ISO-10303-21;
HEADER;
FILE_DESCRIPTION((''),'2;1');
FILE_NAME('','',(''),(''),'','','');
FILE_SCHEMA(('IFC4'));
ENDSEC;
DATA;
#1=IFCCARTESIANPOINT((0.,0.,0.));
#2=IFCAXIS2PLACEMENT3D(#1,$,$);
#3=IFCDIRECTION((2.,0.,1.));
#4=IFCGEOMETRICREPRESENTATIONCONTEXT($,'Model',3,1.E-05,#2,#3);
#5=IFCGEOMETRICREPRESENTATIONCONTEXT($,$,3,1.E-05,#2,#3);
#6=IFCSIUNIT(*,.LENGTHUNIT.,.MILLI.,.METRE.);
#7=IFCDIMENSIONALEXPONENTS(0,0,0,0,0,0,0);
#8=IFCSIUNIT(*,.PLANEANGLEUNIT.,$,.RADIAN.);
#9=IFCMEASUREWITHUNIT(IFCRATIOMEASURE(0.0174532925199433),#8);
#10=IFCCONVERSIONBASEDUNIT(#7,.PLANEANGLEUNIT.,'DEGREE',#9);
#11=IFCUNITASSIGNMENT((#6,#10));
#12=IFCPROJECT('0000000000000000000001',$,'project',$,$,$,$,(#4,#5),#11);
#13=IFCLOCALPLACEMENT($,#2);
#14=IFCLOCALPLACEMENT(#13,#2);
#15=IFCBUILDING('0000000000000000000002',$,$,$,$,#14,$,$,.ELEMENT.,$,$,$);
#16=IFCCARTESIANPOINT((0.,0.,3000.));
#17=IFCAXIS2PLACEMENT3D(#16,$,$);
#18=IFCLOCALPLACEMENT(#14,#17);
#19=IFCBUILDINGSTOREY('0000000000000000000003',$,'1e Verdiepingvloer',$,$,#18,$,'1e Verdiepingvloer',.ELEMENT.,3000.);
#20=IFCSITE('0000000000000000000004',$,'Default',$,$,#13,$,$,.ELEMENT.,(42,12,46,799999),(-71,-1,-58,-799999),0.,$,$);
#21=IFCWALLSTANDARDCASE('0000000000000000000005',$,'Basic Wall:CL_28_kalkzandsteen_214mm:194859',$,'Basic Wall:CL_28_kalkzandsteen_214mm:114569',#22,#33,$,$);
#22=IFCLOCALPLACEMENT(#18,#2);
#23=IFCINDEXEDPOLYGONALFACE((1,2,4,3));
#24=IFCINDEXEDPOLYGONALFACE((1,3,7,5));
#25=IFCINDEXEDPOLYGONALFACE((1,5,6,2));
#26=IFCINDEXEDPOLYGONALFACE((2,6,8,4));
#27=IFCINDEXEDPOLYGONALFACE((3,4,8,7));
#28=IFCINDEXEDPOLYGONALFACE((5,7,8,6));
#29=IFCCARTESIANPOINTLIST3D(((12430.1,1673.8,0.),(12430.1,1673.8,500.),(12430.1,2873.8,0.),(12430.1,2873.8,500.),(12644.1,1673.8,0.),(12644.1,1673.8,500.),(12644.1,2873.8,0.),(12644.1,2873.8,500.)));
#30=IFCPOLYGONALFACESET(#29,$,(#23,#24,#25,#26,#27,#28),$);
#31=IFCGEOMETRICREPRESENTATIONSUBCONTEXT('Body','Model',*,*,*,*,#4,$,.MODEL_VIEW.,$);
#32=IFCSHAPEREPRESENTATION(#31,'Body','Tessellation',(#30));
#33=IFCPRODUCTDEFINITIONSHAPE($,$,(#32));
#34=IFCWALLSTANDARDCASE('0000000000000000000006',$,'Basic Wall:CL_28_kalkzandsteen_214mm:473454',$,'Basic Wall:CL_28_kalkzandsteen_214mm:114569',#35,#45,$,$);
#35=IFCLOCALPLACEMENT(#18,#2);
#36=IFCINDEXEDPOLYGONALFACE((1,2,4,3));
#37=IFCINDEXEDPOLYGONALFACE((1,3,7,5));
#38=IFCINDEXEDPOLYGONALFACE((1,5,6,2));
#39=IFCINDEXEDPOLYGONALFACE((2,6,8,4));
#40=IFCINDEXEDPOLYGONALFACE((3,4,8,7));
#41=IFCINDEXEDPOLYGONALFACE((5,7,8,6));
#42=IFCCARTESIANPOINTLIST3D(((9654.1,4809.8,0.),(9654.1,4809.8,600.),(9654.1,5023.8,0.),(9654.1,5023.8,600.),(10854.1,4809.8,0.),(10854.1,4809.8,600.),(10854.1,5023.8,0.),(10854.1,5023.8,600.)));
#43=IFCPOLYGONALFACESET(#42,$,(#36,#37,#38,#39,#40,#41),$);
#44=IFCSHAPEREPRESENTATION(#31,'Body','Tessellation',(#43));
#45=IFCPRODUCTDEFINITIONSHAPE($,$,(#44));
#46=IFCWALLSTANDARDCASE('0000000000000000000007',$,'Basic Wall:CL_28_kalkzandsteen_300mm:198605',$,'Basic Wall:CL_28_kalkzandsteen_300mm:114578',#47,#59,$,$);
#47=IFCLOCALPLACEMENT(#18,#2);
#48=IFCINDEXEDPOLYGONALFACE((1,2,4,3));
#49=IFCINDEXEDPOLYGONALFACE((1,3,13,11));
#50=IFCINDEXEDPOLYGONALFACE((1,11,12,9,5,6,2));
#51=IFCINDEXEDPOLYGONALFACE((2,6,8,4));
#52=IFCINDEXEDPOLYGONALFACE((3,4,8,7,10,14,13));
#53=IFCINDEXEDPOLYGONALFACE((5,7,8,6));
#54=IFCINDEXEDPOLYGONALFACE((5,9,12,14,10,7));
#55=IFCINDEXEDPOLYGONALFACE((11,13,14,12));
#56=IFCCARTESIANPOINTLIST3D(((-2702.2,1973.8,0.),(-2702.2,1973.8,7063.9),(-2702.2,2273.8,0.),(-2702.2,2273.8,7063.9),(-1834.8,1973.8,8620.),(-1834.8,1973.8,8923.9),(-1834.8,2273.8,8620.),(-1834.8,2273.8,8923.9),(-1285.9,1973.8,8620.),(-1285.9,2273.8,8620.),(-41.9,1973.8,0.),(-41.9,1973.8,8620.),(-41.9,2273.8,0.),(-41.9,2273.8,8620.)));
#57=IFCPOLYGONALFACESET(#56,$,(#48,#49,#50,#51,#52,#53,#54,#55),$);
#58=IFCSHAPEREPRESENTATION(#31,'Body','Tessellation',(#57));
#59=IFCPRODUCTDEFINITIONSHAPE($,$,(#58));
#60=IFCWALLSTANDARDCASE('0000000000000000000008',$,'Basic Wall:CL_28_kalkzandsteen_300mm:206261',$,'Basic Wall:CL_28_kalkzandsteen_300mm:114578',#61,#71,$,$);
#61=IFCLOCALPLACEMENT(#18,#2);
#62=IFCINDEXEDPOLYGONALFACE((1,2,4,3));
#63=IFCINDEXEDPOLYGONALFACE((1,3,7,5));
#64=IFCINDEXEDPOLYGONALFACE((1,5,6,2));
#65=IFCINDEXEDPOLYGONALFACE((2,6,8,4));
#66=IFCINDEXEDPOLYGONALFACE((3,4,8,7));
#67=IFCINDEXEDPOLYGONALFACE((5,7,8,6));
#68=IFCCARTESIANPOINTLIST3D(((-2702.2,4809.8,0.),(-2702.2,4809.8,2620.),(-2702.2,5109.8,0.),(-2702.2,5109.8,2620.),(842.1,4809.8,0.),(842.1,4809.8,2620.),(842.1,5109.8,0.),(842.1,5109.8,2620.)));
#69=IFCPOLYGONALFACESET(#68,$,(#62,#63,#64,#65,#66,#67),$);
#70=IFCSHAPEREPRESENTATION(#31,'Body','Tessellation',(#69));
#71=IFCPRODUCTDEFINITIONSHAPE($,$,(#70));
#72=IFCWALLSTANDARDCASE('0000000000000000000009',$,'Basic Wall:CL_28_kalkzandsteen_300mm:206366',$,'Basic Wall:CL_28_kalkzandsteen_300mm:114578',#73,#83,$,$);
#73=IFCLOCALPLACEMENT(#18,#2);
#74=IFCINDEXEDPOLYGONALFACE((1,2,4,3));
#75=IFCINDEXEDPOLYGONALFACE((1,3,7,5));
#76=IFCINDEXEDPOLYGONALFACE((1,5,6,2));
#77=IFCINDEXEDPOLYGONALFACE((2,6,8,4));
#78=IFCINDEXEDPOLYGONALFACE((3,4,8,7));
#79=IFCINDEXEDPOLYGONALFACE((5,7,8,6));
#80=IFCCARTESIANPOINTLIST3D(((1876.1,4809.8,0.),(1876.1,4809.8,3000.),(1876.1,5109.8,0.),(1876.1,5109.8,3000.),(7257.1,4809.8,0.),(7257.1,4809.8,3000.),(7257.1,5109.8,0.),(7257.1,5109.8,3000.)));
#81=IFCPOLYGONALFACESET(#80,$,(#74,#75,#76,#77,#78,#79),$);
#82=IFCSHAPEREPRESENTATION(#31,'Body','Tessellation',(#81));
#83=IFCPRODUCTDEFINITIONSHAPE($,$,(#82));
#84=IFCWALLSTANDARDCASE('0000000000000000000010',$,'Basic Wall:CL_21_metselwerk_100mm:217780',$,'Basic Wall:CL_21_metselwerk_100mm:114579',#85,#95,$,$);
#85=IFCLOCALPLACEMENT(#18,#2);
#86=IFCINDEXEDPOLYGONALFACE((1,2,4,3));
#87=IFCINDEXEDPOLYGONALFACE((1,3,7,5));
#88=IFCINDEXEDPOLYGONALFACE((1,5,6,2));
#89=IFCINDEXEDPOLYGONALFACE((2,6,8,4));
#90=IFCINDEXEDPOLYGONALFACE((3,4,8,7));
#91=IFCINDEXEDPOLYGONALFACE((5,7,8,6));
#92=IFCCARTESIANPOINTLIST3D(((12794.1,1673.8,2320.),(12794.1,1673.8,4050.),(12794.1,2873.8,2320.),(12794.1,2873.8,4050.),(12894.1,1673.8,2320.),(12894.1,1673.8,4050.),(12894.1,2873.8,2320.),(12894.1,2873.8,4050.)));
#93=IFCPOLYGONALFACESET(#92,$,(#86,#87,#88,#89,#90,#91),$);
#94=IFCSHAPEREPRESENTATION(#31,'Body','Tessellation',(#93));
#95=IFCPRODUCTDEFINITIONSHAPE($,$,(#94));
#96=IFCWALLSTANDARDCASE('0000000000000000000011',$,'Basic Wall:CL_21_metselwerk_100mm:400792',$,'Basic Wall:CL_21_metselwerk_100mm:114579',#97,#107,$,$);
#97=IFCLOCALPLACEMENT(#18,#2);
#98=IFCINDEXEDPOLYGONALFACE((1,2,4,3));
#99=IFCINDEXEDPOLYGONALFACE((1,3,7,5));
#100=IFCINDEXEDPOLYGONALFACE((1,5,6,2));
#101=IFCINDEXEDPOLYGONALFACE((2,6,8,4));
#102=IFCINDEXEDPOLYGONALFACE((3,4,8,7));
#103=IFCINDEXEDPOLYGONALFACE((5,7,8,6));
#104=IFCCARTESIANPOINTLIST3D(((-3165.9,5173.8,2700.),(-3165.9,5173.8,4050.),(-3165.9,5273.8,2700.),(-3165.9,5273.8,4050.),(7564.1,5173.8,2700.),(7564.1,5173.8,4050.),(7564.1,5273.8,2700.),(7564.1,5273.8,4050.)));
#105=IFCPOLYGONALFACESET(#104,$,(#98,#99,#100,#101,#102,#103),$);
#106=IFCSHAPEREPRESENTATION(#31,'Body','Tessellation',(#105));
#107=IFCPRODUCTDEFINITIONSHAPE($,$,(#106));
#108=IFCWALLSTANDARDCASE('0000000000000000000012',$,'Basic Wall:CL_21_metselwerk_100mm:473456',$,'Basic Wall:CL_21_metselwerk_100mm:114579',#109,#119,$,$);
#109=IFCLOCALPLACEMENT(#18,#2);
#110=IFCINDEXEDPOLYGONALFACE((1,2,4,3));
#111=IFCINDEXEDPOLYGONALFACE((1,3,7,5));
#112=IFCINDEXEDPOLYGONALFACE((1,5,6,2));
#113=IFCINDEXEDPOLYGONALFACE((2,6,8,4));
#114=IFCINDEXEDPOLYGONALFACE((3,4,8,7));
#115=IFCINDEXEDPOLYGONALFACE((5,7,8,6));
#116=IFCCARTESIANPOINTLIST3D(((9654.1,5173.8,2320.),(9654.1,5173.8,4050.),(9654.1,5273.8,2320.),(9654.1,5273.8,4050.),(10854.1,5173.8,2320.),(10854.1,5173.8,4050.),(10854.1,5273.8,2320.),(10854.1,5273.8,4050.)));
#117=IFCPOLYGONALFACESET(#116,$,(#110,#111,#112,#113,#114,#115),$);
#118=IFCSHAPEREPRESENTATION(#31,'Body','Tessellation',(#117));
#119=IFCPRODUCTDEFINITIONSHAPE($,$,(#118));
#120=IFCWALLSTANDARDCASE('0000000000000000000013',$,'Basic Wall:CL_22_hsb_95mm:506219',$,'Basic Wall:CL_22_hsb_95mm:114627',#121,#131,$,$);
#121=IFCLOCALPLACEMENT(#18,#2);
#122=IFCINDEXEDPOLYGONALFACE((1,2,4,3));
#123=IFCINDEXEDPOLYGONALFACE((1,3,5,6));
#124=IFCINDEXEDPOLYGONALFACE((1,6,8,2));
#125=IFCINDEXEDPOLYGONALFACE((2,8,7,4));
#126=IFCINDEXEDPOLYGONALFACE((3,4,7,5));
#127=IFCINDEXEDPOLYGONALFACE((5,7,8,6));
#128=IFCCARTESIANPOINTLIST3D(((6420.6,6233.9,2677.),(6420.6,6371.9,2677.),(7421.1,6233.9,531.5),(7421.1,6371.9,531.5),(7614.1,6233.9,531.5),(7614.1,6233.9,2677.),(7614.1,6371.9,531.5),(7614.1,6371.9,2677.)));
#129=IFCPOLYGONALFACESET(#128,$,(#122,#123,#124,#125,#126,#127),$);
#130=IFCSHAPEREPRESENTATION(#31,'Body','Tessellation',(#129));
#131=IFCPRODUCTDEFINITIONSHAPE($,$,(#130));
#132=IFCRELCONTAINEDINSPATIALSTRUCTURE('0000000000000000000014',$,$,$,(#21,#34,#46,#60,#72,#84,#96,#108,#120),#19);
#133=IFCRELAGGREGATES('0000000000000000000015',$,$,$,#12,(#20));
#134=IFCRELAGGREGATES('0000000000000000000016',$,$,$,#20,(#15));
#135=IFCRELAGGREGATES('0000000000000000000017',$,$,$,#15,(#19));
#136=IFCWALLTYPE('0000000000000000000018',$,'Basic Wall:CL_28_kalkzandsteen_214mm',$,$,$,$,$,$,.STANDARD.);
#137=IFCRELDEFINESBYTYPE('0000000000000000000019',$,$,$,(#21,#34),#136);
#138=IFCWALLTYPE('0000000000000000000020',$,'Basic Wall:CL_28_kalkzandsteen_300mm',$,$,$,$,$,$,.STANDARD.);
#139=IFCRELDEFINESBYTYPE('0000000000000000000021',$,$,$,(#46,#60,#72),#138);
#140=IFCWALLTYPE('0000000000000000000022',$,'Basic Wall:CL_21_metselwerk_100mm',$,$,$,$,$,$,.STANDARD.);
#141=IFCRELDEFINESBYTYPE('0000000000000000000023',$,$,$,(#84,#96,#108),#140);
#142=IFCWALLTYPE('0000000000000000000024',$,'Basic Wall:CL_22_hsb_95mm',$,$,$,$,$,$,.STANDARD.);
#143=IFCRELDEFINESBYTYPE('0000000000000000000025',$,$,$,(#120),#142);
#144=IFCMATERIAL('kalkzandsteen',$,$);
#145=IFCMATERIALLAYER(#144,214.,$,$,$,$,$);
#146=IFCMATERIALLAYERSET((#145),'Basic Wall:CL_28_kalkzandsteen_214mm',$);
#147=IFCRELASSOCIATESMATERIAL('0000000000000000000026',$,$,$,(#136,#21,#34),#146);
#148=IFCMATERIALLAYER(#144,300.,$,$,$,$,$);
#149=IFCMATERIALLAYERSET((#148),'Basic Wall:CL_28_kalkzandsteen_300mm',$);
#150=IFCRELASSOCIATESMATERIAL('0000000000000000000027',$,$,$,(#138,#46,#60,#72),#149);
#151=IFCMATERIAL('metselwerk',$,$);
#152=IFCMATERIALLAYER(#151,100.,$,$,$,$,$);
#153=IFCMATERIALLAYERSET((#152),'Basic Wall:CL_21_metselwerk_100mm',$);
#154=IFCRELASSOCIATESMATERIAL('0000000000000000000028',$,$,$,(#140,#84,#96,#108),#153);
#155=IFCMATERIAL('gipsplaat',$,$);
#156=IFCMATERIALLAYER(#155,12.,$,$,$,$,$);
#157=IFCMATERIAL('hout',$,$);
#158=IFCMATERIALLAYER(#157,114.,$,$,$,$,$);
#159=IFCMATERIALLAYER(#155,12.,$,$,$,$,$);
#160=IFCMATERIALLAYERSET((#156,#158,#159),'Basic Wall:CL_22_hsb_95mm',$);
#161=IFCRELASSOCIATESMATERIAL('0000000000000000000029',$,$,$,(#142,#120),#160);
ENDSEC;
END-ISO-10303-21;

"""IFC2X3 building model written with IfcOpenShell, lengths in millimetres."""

from ifc_helpers import new_model, entity, si_unit, converted_unit, direction, frame, frame_2d, origin, place, context, subcontext, project, spatial, polyline, rectangle, extrude, clip, halfspace, bounded_halfspace, material, layer, layer_set, layer_usage, type_object, element, save


model = new_model("IFC2X3")

# Units and contexts
model_context = context("Model", 3, precision=1e-05, world=origin(), true_north=direction((2.0, 0.0, 1.0)))
context_of_model = context(None, 3, precision=1e-05, world=origin(), true_north=direction((2.0, 0.0, 1.0)))
body_context = subcontext(model_context, "Body", "Model", "MODEL_VIEW")
ifc_project = project(units=[si_unit("LENGTHUNIT", "METRE", prefix="MILLI"), converted_unit("PLANEANGLEUNIT", "DEGREE", entity("IfcRatioMeasure", 0.0174532925199433), si_unit("PLANEANGLEUNIT", "RADIAN"), dimensions=[0, 0, 0, 0, 0, 0, 0])], contexts=[model_context, context_of_model])

# Site, building, storey
site_placement = place(None, origin())
site = spatial("IfcSite", under=ifc_project, at=site_placement, Name="Default", CompositionType="ELEMENT", RefLatitude=(42, 12, 46, 799999), RefLongitude=(-71, -1, -58, -799999), RefElevation=0.0)
building_placement = place(site_placement, origin())
building = spatial("IfcBuilding", under=site, at=building_placement, CompositionType="ELEMENT")
storey_placement = place(building_placement, frame((0.0, 0.0, 3000.0)))
storey = spatial("IfcBuildingStorey", under=building, at=storey_placement, Name="1e Verdiepingvloer", LongName="1e Verdiepingvloer", CompositionType="ELEMENT", Elevation=3000.0)

# Shared definitions
ifc_material_1 = material(Name="hout")

# Walls
ifc_material_2 = material(Name="kalkzandsteen")
ifc_layer_1 = layer(ifc_material_2, 214.0)
ifc_layer_set_1 = layer_set([ifc_layer_1], Name="Basic Wall:CL_28_kalkzandsteen_214mm")
ifc_layer_usage_1 = layer_usage(ifc_layer_set_1, "AXIS2", "NEGATIVE", 107.0)
wall_type_1 = type_object("IfcWallType", Name="Basic Wall:CL_28_kalkzandsteen_214mm", PredefinedType="STANDARD", material=ifc_layer_set_1)
wall_1_placement = place(storey_placement, frame((12537.1, 1673.8, 0.0), z_axis=(0.0, 0.0, 1.0), x_axis=(0.0, 1.0, 0.0)))
element("IfcWallStandardCase", 1, at=wall_1_placement, inside=storey, type_object=wall_type_1, material=ifc_layer_usage_1, Name="Basic Wall:CL_28_kalkzandsteen_214mm:194859", ObjectType="Basic Wall:CL_28_kalkzandsteen_214mm:114569", context=body_context, shape_type="SweptSolid", body=[
    extrude(rectangle(XDim=1200.0, YDim=214.0, at=frame_2d((600.0, 0.0), x_axis=(-1.0, 0.0))), origin(), (0.0, 0.0, 1.0), 500.0),
])
ifc_layer_usage_2 = layer_usage(ifc_layer_set_1, "AXIS2", "NEGATIVE", 107.0)
wall_2_placement = place(storey_placement, frame((10854.1, 4916.8, 0.0), z_axis=(0.0, 0.0, 1.0), x_axis=(-1.0, 0.0, 0.0)))
element("IfcWallStandardCase", 2, at=wall_2_placement, inside=storey, type_object=wall_type_1, material=ifc_layer_usage_2, Name="Basic Wall:CL_28_kalkzandsteen_214mm:473454", ObjectType="Basic Wall:CL_28_kalkzandsteen_214mm:114569", context=body_context, shape_type="SweptSolid", body=[
    extrude(rectangle(XDim=1200.0, YDim=214.0, at=frame_2d((600.0, 0.0), x_axis=(-1.0, 0.0))), origin(), (0.0, 0.0, 1.0), 600.0),
])
ifc_layer_2 = layer(ifc_material_2, 300.0)
ifc_layer_set_2 = layer_set([ifc_layer_2], Name="Basic Wall:CL_28_kalkzandsteen_300mm")
ifc_layer_usage_3 = layer_usage(ifc_layer_set_2, "AXIS2", "NEGATIVE", 150.0)
wall_type_2 = type_object("IfcWallType", Name="Basic Wall:CL_28_kalkzandsteen_300mm", PredefinedType="STANDARD", material=ifc_layer_set_2)
wall_3_placement = place(storey_placement, frame((-41.9, 2123.8, 0.0), z_axis=(0.0, 0.0, 1.0), x_axis=(-1.0, 0.0, 0.0)))
element("IfcWallStandardCase", 3, at=wall_3_placement, inside=storey, type_object=wall_type_2, material=ifc_layer_usage_3, Name="Basic Wall:CL_28_kalkzandsteen_300mm:198605", ObjectType="Basic Wall:CL_28_kalkzandsteen_300mm:114578", context=body_context, shape_type="Clipping", body=[
    clip(clip(clip(clip(extrude(rectangle(XDim=2660.3, YDim=300.0, at=frame_2d((1330.1, 0.0), x_axis=(-1.0, 0.0))), origin(), (0.0, 0.0, 1.0), 8923.9), bounded_halfspace(frame((0.0, -150.0, 8620.0), z_axis=(0.0, 0.0, -1.0), x_axis=(0.0, 1.0, 0.0)), True, frame((0.0, -150.0, 8620.0)), polyline([(0.0, 0.0), (1244.0, 0.0), (1244.0, 300.0), (0.0, 300.0), (0.0, 0.0)]))), bounded_halfspace(frame((1792.9, -150.0, 8923.9), z_axis=(0.906308, 0.0, 0.422618), x_axis=(0.0, 1.0, 0.0)), False, frame((1792.9, -150.0, 8923.9)), polyline([(0.0, 0.0), (867.4, 0.0), (867.4, 300.0), (0.0, 300.0), (0.0, 0.0)]))), bounded_halfspace(frame((0.0, -150.0, 8620.0), z_axis=(0.0, 0.0, -1.0), x_axis=(0.0, 1.0, 0.0)), True, frame((0.0, -150.0, 8620.0)), polyline([(0.0, 0.0), (1244.0, 0.0), (1244.0, 300.0), (0.0, 300.0), (0.0, 0.0)]))), bounded_halfspace(frame((1244.0, -150.0, 8620.0), z_axis=(0.0, 0.0, 1.0), x_axis=(0.0, 1.0, 0.0)), False, frame((1244.0, -150.0, 8620.0)), polyline([(0.0, 0.0), (548.9, 0.0), (548.9, 300.0), (0.0, 300.0), (0.0, 0.0)]))),
])
ifc_layer_usage_4 = layer_usage(ifc_layer_set_2, "AXIS2", "NEGATIVE", 150.0)
wall_4_placement = place(storey_placement, frame((842.1, 4959.8, 0.0), z_axis=(0.0, 0.0, 1.0), x_axis=(-1.0, 0.0, 0.0)))
element("IfcWallStandardCase", 4, at=wall_4_placement, inside=storey, type_object=wall_type_2, material=ifc_layer_usage_4, Name="Basic Wall:CL_28_kalkzandsteen_300mm:206261", ObjectType="Basic Wall:CL_28_kalkzandsteen_300mm:114578", context=body_context, shape_type="SweptSolid", body=[
    extrude(rectangle(XDim=3544.3, YDim=300.0, at=frame_2d((1772.1, 0.0), x_axis=(-1.0, 0.0))), origin(), (0.0, 0.0, 1.0), 2620.0),
])
ifc_layer_usage_5 = layer_usage(ifc_layer_set_2, "AXIS2", "NEGATIVE", 150.0)
wall_5_placement = place(storey_placement, frame((7257.1, 4959.8, 0.0), z_axis=(0.0, 0.0, 1.0), x_axis=(-1.0, 0.0, 0.0)))
element("IfcWallStandardCase", 5, at=wall_5_placement, inside=storey, type_object=wall_type_2, material=ifc_layer_usage_5, Name="Basic Wall:CL_28_kalkzandsteen_300mm:206366", ObjectType="Basic Wall:CL_28_kalkzandsteen_300mm:114578", context=body_context, shape_type="SweptSolid", body=[
    extrude(rectangle(XDim=5381.0, YDim=300.0, at=frame_2d((2690.5, 0.0), x_axis=(-1.0, 0.0))), origin(), (0.0, 0.0, 1.0), 3000.0),
])
ifc_material_3 = material(Name="metselwerk")
ifc_layer_3 = layer(ifc_material_3, 100.0)
ifc_layer_set_3 = layer_set([ifc_layer_3], Name="Basic Wall:CL_21_metselwerk_100mm")
ifc_layer_usage_6 = layer_usage(ifc_layer_set_3, "AXIS2", "NEGATIVE", 50.0)
wall_type_3 = type_object("IfcWallType", Name="Basic Wall:CL_21_metselwerk_100mm", PredefinedType="STANDARD", material=ifc_layer_set_3)
wall_6_placement = place(storey_placement, frame((12844.1, 1673.8, 2320.0), z_axis=(0.0, 0.0, 1.0), x_axis=(0.0, 1.0, 0.0)))
element("IfcWallStandardCase", 6, at=wall_6_placement, inside=storey, type_object=wall_type_3, material=ifc_layer_usage_6, Name="Basic Wall:CL_21_metselwerk_100mm:217780", ObjectType="Basic Wall:CL_21_metselwerk_100mm:114579", context=body_context, shape_type="SweptSolid", body=[
    extrude(rectangle(XDim=1200.0, YDim=100.0, at=frame_2d((600.0, 0.0), x_axis=(-1.0, 0.0))), origin(), (0.0, 0.0, 1.0), 1730.0),
])
ifc_layer_usage_7 = layer_usage(ifc_layer_set_3, "AXIS2", "NEGATIVE", 50.0)
wall_7_placement = place(storey_placement, frame((7564.1, 5223.8, 2700.0), z_axis=(0.0, 0.0, 1.0), x_axis=(-1.0, 0.0, 0.0)))
element("IfcWallStandardCase", 7, at=wall_7_placement, inside=storey, type_object=wall_type_3, material=ifc_layer_usage_7, Name="Basic Wall:CL_21_metselwerk_100mm:400792", ObjectType="Basic Wall:CL_21_metselwerk_100mm:114579", context=body_context, shape_type="SweptSolid", body=[
    extrude(rectangle(XDim=10730.0, YDim=100.0, at=frame_2d((5365.0, 0.0), x_axis=(-1.0, 0.0))), origin(), (0.0, 0.0, 1.0), 1350.0),
])
ifc_layer_usage_8 = layer_usage(ifc_layer_set_3, "AXIS2", "NEGATIVE", 50.0)
wall_8_placement = place(storey_placement, frame((10854.1, 5223.8, 2320.0), z_axis=(0.0, 0.0, 1.0), x_axis=(-1.0, 0.0, 0.0)))
element("IfcWallStandardCase", 8, at=wall_8_placement, inside=storey, type_object=wall_type_3, material=ifc_layer_usage_8, Name="Basic Wall:CL_21_metselwerk_100mm:473456", ObjectType="Basic Wall:CL_21_metselwerk_100mm:114579", context=body_context, shape_type="SweptSolid", body=[
    extrude(rectangle(XDim=1200.0, YDim=100.0, at=frame_2d((600.0, 0.0), x_axis=(-1.0, 0.0))), origin(), (0.0, 0.0, 1.0), 1730.0),
])

# Wall
ifc_material_4 = material(Name="gipsplaat")
ifc_layer_4 = layer(ifc_material_4, 12.0)
ifc_layer_5 = layer(ifc_material_1, 114.0)
ifc_layer_6 = layer(ifc_material_4, 12.0)
ifc_layer_set_4 = layer_set([ifc_layer_4, ifc_layer_5, ifc_layer_6], Name="Basic Wall:CL_22_hsb_95mm")
ifc_layer_usage_9 = layer_usage(ifc_layer_set_4, "AXIS2", "NEGATIVE", 69.0)
wall_type_4 = type_object("IfcWallType", Name="Basic Wall:CL_22_hsb_95mm", PredefinedType="STANDARD", material=ifc_layer_set_4)
wall_9_placement = place(storey_placement, frame((6420.6, 6302.9, 0.0)))
element("IfcWallStandardCase", 9, at=wall_9_placement, inside=storey, type_object=wall_type_4, material=ifc_layer_usage_9, Name="Basic Wall:CL_22_hsb_95mm:506219", ObjectType="Basic Wall:CL_22_hsb_95mm:114627", context=body_context, shape_type="Clipping", body=[
    clip(clip(extrude(rectangle(XDim=1193.5, YDim=138.0, at=frame_2d((596.7, 0.0), x_axis=(-1.0, 0.0))), origin(), (0.0, 0.0, 1.0), 2677.0), halfspace(frame((1000.5, -69.0, 531.5), z_axis=(-0.906308, 0.0, -0.422618), x_axis=(0.0, 1.0, 0.0)), False)), halfspace(frame((1193.5, -69.0, 531.5), z_axis=(0.0, 0.0, -1.0), x_axis=(0.0, 1.0, 0.0)), False)),
])

save(model, "model.ifc")
